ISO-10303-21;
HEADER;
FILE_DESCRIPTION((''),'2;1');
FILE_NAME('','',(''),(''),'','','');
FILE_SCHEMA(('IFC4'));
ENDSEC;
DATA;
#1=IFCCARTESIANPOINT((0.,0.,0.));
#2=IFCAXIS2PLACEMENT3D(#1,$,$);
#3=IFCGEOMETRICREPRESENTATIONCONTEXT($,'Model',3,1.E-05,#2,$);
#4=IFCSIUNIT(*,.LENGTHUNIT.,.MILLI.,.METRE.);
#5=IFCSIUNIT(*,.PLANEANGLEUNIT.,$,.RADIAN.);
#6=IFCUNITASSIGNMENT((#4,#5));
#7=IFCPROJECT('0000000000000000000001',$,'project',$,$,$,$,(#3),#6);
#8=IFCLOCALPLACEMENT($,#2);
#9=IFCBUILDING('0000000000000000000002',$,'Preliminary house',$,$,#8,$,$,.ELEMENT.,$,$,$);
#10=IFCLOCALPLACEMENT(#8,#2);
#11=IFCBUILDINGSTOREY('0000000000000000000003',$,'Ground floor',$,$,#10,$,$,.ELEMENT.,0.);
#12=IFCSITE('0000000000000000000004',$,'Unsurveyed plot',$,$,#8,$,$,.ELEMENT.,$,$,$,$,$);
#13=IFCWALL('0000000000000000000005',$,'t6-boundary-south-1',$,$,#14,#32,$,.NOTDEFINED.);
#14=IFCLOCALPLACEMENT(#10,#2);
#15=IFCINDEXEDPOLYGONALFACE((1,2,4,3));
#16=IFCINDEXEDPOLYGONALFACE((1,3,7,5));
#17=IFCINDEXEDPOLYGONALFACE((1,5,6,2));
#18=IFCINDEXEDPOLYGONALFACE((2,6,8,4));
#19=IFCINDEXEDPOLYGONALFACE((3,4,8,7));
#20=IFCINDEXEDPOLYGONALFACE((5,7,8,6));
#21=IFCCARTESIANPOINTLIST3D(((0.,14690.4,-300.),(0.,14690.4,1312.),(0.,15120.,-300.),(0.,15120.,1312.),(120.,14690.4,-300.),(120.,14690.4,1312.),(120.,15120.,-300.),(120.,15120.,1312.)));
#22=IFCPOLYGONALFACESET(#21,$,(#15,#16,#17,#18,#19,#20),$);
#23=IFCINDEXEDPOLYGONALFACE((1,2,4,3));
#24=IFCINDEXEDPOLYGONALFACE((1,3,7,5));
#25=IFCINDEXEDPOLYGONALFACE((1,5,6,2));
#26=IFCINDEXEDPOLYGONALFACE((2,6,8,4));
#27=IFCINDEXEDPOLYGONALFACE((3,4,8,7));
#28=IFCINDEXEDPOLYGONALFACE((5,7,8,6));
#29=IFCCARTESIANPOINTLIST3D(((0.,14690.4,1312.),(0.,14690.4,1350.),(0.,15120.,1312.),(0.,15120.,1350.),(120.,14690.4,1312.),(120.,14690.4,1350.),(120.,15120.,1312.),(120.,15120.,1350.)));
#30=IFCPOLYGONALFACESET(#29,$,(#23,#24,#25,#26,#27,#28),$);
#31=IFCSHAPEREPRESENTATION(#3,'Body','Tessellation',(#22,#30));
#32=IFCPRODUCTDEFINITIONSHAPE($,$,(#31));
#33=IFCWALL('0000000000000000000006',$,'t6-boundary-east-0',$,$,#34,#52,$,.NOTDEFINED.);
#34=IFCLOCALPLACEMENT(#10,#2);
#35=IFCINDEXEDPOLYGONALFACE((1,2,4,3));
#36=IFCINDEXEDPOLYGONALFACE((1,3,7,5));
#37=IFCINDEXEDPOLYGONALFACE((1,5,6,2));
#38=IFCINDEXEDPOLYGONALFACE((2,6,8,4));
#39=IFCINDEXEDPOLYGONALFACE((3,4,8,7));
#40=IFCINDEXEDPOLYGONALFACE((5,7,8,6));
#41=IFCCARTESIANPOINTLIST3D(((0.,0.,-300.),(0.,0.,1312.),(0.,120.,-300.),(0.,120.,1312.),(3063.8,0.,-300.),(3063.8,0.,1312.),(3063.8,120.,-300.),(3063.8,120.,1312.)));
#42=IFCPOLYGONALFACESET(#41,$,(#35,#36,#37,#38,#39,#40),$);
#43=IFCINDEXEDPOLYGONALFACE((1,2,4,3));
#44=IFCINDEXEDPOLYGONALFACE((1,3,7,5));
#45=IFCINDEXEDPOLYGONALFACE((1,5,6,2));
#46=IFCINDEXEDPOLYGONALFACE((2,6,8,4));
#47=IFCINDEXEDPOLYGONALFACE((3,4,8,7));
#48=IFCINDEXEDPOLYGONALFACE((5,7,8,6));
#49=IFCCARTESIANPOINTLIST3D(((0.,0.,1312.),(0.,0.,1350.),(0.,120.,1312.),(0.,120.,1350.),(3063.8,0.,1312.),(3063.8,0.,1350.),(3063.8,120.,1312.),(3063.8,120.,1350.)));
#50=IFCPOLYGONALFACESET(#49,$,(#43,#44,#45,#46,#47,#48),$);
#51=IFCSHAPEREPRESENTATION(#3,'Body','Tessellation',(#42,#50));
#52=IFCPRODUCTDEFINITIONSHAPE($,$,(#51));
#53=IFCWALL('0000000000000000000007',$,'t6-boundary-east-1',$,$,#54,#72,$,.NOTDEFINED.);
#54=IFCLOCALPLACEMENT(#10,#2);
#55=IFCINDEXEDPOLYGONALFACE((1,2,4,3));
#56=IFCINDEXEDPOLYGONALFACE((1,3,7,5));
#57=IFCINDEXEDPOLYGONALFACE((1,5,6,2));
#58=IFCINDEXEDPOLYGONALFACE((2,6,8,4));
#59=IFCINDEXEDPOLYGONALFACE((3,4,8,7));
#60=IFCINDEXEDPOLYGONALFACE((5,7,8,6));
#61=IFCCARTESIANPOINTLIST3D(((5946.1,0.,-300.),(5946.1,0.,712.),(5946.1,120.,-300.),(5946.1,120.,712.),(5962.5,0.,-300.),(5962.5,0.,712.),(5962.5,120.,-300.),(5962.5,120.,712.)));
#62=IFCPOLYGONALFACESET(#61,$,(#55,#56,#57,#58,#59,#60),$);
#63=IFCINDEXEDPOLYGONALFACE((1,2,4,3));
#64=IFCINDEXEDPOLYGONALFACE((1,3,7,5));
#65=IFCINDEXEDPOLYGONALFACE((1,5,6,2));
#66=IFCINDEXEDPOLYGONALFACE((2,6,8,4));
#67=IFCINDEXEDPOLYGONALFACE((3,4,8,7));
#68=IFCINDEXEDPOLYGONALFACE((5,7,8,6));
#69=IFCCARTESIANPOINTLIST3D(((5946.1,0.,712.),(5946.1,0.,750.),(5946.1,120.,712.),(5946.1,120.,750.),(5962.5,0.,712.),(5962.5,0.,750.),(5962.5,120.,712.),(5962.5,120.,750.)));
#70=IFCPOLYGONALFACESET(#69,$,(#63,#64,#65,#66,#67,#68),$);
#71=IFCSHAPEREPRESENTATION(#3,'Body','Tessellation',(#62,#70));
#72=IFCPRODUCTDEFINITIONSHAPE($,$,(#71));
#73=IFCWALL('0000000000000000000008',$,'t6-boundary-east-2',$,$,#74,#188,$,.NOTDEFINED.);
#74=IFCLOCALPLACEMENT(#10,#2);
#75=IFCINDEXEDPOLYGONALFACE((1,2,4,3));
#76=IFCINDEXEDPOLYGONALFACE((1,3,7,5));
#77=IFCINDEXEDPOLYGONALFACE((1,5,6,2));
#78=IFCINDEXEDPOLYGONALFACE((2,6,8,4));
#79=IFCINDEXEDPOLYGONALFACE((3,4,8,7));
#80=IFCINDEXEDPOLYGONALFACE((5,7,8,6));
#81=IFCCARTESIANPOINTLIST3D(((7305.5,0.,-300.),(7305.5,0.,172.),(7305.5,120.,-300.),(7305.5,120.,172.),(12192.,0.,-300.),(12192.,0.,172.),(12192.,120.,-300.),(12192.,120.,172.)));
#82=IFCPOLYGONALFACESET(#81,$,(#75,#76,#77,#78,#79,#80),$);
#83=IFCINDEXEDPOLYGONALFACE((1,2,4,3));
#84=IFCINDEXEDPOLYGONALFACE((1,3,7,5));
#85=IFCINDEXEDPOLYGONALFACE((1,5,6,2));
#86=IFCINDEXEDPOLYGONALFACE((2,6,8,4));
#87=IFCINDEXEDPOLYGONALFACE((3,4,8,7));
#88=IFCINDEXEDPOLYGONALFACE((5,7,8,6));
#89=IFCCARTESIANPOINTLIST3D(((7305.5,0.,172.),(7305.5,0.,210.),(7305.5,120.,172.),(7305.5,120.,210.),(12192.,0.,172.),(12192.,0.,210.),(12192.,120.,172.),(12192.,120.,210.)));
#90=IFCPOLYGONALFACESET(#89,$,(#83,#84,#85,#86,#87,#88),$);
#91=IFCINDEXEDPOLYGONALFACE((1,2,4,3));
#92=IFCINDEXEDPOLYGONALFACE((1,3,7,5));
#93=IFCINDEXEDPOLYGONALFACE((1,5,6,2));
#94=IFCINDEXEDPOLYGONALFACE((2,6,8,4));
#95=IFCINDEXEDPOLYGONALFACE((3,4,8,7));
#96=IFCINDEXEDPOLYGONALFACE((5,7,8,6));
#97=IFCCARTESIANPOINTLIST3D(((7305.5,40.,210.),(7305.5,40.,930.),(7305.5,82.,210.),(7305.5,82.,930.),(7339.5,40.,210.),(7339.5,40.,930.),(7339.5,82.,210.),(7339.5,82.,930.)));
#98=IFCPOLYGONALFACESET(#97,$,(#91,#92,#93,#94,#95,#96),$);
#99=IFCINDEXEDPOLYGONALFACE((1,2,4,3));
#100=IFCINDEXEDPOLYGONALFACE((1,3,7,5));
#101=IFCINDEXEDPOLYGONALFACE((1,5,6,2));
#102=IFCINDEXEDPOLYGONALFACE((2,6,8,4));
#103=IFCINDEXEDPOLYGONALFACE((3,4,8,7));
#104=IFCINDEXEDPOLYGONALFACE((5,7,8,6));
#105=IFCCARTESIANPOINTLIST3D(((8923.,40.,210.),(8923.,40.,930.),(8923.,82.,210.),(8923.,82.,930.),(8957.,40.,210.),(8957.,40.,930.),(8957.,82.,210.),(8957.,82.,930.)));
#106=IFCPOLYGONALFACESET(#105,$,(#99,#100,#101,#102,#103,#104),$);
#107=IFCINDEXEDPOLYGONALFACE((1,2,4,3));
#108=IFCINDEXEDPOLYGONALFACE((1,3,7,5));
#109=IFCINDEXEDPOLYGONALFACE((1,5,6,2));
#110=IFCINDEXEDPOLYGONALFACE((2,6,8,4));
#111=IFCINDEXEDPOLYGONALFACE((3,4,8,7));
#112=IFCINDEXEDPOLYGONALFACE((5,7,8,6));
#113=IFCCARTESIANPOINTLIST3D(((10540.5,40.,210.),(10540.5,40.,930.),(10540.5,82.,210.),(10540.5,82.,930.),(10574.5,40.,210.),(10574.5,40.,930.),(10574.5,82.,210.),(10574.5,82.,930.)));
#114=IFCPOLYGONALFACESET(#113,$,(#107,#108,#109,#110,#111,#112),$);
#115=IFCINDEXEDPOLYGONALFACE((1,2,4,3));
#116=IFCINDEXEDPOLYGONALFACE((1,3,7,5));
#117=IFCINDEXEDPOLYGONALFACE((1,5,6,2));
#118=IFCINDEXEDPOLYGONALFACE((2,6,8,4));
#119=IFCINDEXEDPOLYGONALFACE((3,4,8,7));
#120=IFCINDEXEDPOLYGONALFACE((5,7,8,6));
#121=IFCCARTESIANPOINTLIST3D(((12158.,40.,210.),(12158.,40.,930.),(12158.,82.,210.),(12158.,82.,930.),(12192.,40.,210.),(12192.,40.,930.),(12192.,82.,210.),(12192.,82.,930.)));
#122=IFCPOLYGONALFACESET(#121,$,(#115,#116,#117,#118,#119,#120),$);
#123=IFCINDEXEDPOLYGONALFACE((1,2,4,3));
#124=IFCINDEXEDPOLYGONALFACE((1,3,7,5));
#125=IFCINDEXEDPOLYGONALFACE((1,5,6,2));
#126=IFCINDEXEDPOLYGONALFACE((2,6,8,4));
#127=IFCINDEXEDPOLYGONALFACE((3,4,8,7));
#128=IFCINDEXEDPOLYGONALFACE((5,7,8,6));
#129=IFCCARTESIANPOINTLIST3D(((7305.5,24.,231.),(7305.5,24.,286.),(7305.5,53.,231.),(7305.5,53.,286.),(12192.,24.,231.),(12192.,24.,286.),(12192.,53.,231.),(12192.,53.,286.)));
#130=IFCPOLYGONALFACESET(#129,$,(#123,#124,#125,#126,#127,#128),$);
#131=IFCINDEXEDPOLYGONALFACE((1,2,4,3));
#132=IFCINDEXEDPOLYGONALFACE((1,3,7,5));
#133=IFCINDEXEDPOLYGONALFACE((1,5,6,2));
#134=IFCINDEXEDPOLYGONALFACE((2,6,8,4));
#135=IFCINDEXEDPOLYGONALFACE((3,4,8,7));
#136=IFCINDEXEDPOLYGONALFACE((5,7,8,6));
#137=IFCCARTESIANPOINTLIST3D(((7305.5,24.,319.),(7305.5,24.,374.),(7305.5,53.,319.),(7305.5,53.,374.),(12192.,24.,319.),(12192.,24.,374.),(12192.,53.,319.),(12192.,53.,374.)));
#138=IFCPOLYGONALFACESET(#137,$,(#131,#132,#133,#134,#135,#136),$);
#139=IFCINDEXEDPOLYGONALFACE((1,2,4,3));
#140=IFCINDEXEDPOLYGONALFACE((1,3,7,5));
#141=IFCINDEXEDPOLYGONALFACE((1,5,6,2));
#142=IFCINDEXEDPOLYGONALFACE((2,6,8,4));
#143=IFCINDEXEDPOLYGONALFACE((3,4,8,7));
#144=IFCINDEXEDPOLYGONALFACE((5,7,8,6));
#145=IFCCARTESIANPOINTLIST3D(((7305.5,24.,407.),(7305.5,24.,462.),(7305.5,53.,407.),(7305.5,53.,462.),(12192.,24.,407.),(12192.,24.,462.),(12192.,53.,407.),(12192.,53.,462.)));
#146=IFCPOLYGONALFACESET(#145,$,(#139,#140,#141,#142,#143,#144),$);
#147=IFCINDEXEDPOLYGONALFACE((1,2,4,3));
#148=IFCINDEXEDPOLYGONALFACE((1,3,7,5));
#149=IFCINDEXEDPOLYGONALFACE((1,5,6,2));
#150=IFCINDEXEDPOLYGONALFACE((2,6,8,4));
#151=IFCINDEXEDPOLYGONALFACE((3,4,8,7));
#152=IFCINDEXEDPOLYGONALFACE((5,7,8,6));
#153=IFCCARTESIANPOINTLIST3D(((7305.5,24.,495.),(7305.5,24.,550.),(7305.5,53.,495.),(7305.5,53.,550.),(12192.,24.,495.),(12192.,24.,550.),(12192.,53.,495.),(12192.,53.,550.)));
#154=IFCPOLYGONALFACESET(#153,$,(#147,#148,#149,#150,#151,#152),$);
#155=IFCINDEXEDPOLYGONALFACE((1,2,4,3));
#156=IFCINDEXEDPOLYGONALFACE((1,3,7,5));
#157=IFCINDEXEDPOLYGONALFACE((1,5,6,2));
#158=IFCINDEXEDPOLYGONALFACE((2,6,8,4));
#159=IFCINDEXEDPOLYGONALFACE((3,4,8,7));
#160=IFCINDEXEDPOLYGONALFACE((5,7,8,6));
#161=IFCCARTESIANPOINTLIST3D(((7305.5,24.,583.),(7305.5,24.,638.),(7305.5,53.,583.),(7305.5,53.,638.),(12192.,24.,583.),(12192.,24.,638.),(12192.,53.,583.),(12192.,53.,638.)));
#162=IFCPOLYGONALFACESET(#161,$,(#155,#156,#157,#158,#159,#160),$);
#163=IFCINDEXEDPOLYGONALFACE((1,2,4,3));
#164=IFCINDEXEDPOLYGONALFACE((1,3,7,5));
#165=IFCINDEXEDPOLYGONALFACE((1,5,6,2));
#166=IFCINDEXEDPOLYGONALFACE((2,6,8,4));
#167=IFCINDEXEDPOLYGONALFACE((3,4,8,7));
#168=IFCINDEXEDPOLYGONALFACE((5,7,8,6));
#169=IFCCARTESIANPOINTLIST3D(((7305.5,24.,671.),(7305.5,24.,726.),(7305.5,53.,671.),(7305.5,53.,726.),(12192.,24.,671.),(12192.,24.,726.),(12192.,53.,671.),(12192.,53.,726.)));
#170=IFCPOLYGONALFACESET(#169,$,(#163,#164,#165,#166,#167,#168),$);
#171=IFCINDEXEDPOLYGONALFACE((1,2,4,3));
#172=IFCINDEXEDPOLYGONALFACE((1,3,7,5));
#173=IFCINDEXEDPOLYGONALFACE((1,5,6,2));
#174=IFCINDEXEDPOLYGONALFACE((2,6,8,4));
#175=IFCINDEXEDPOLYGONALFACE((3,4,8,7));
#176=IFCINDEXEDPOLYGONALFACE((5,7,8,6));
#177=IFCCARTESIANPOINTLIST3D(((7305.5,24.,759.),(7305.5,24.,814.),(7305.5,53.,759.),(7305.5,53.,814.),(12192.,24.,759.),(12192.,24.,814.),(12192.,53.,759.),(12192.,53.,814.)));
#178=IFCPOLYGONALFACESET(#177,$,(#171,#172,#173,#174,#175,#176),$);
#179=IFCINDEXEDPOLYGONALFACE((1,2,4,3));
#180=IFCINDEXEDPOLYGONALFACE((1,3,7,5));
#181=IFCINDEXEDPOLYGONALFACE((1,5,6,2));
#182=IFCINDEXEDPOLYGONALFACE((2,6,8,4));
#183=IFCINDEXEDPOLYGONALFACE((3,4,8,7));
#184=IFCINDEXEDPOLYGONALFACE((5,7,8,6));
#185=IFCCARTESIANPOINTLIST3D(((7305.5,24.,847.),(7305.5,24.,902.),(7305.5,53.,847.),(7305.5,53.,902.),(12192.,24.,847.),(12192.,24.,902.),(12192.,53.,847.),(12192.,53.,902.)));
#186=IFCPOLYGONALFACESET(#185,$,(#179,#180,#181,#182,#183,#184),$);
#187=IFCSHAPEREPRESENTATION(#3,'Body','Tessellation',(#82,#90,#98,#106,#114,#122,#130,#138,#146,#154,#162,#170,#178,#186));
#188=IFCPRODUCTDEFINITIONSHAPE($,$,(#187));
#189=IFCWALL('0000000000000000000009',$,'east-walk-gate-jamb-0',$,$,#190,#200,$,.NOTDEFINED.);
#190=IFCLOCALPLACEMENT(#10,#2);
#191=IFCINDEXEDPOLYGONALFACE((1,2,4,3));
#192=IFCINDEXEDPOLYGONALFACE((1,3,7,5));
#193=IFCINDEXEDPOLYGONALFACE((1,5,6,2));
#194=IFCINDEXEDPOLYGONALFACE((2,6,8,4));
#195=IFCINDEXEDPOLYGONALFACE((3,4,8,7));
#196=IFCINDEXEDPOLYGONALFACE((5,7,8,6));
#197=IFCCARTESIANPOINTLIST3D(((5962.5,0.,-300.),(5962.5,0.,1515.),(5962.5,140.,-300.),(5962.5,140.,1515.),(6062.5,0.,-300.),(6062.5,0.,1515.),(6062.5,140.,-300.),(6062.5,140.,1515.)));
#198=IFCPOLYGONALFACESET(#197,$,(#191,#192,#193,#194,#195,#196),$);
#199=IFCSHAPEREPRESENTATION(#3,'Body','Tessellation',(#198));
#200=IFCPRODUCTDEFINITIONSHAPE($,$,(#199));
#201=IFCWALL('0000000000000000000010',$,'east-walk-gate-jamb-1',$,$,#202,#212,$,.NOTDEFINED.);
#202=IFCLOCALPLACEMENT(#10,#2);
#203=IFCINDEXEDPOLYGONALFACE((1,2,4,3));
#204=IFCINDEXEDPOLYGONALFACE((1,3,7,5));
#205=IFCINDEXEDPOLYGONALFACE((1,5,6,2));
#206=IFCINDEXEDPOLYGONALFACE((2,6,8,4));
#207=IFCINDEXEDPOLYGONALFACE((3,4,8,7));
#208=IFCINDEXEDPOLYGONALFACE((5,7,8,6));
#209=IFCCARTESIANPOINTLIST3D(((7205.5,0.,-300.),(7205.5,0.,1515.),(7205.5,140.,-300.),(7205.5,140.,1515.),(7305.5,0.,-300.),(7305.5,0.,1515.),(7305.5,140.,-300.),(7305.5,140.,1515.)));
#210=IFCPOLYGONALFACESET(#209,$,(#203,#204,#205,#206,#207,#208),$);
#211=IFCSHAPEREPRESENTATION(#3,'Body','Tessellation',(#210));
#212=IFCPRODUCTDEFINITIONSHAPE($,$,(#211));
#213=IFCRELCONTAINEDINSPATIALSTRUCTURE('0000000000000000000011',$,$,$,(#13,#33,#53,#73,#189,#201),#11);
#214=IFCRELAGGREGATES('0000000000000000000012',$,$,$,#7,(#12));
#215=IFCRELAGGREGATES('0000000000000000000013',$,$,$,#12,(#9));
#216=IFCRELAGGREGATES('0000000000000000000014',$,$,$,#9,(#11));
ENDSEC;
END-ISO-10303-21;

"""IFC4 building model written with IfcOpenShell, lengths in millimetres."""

from ifc_helpers import new_model, si_unit, frame, origin, place, context, project, spatial, polyline, outline, extrude, element, save


model = new_model("IFC4")

# Units and contexts
model_context = context("Model", 3, precision=1e-05, world=origin())
ifc_project = project(units=[si_unit("LENGTHUNIT", "METRE", prefix="MILLI"), si_unit("PLANEANGLEUNIT", "RADIAN")], contexts=[model_context])

# Site, building, storey
placement_1 = place(None, origin())
site = spatial("IfcSite", under=ifc_project, at=placement_1, Name="Unsurveyed plot", CompositionType="ELEMENT")
building = spatial("IfcBuilding", under=site, at=placement_1, Name="Preliminary house", CompositionType="ELEMENT")
placement_2 = place(placement_1, origin())
storey = spatial("IfcBuildingStorey", under=building, at=placement_2, Name="Ground floor", CompositionType="ELEMENT", Elevation=0.0)

# Walls
element("IfcWall", 1, at=placement_2, inside=storey, Name="t6-boundary-south-1", PredefinedType="NOTDEFINED", context=model_context, shape_type="SweptSolid", body=[
    extrude(outline(polyline([(120.0, 14690.4), (120.0, 15120.0), (0.0, 15120.0), (0.0, 14690.4), (120.0, 14690.4)])), frame((0.0, 0.0, -300.0)), (0.0, 0.0, 1.0), 1612.0),
    extrude(outline(polyline([(120.0, 14690.4), (120.0, 15120.0), (0.0, 15120.0), (0.0, 14690.4), (120.0, 14690.4)])), frame((0.0, 0.0, 1312.0)), (0.0, 0.0, 1.0), 38.0),
])
element("IfcWall", 2, at=placement_2, inside=storey, Name="t6-boundary-east-0", PredefinedType="NOTDEFINED", context=model_context, shape_type="SweptSolid", body=[
    extrude(outline(polyline([(3063.8, 0.0), (3063.8, 120.0), (0.0, 120.0), (0.0, 0.0), (3063.8, 0.0)])), frame((0.0, 0.0, -300.0)), (0.0, 0.0, 1.0), 1612.0),
    extrude(outline(polyline([(3063.8, 0.0), (3063.8, 120.0), (0.0, 120.0), (0.0, 0.0), (3063.8, 0.0)])), frame((0.0, 0.0, 1312.0)), (0.0, 0.0, 1.0), 38.0),
])
element("IfcWall", 3, at=placement_2, inside=storey, Name="t6-boundary-east-1", PredefinedType="NOTDEFINED", context=model_context, shape_type="SweptSolid", body=[
    extrude(outline(polyline([(5962.5, 0.0), (5962.5, 120.0), (5946.1, 120.0), (5946.1, 0.0), (5962.5, 0.0)])), frame((0.0, 0.0, -300.0)), (0.0, 0.0, 1.0), 1012.0),
    extrude(outline(polyline([(5962.5, 0.0), (5962.5, 120.0), (5946.1, 120.0), (5946.1, 0.0), (5962.5, 0.0)])), frame((0.0, 0.0, 712.0)), (0.0, 0.0, 1.0), 38.0),
])
element("IfcWall", 4, at=placement_2, inside=storey, Name="t6-boundary-east-2", PredefinedType="NOTDEFINED", context=model_context, shape_type="SweptSolid", body=[
    extrude(outline(polyline([(12192.0, 0.0), (12192.0, 120.0), (7305.5, 120.0), (7305.5, 0.0), (12192.0, 0.0)])), frame((0.0, 0.0, -300.0)), (0.0, 0.0, 1.0), 472.0),
    extrude(outline(polyline([(12192.0, 0.0), (12192.0, 120.0), (7305.5, 120.0), (7305.5, 0.0), (12192.0, 0.0)])), frame((0.0, 0.0, 172.0)), (0.0, 0.0, 1.0), 38.0),
    extrude(outline(polyline([(7339.5, 40.0), (7339.5, 82.0), (7305.5, 82.0), (7305.5, 40.0), (7339.5, 40.0)])), frame((0.0, 0.0, 210.0)), (0.0, 0.0, 1.0), 720.0),
    extrude(outline(polyline([(8957.0, 40.0), (8957.0, 82.0), (8923.0, 82.0), (8923.0, 40.0), (8957.0, 40.0)])), frame((0.0, 0.0, 210.0)), (0.0, 0.0, 1.0), 720.0),
    extrude(outline(polyline([(10574.5, 40.0), (10574.5, 82.0), (10540.5, 82.0), (10540.5, 40.0), (10574.5, 40.0)])), frame((0.0, 0.0, 210.0)), (0.0, 0.0, 1.0), 720.0),
    extrude(outline(polyline([(12192.0, 40.0), (12192.0, 82.0), (12158.0, 82.0), (12158.0, 40.0), (12192.0, 40.0)])), frame((0.0, 0.0, 210.0)), (0.0, 0.0, 1.0), 720.0),
    extrude(outline(polyline([(12192.0, 24.0), (12192.0, 53.0), (7305.5, 53.0), (7305.5, 24.0), (12192.0, 24.0)])), frame((0.0, 0.0, 231.0)), (0.0, 0.0, 1.0), 55.0),
    extrude(outline(polyline([(12192.0, 24.0), (12192.0, 53.0), (7305.5, 53.0), (7305.5, 24.0), (12192.0, 24.0)])), frame((0.0, 0.0, 319.0)), (0.0, 0.0, 1.0), 55.0),
    extrude(outline(polyline([(12192.0, 24.0), (12192.0, 53.0), (7305.5, 53.0), (7305.5, 24.0), (12192.0, 24.0)])), frame((0.0, 0.0, 407.0)), (0.0, 0.0, 1.0), 55.0),
    extrude(outline(polyline([(12192.0, 24.0), (12192.0, 53.0), (7305.5, 53.0), (7305.5, 24.0), (12192.0, 24.0)])), frame((0.0, 0.0, 495.0)), (0.0, 0.0, 1.0), 55.0),
    extrude(outline(polyline([(12192.0, 24.0), (12192.0, 53.0), (7305.5, 53.0), (7305.5, 24.0), (12192.0, 24.0)])), frame((0.0, 0.0, 583.0)), (0.0, 0.0, 1.0), 55.0),
    extrude(outline(polyline([(12192.0, 24.0), (12192.0, 53.0), (7305.5, 53.0), (7305.5, 24.0), (12192.0, 24.0)])), frame((0.0, 0.0, 671.0)), (0.0, 0.0, 1.0), 55.0),
    extrude(outline(polyline([(12192.0, 24.0), (12192.0, 53.0), (7305.5, 53.0), (7305.5, 24.0), (12192.0, 24.0)])), frame((0.0, 0.0, 759.0)), (0.0, 0.0, 1.0), 55.0),
    extrude(outline(polyline([(12192.0, 24.0), (12192.0, 53.0), (7305.5, 53.0), (7305.5, 24.0), (12192.0, 24.0)])), frame((0.0, 0.0, 847.0)), (0.0, 0.0, 1.0), 55.0),
])
element("IfcWall", 5, at=placement_2, inside=storey, Name="east-walk-gate-jamb-0", PredefinedType="NOTDEFINED", context=model_context, shape_type="SweptSolid", body=[
    extrude(outline(polyline([(6062.5, 0.0), (6062.5, 140.0), (5962.5, 140.0), (5962.5, 0.0), (6062.5, 0.0)])), frame((0.0, 0.0, -300.0)), (0.0, 0.0, 1.0), 1815.0),
])
element("IfcWall", 6, at=placement_2, inside=storey, Name="east-walk-gate-jamb-1", PredefinedType="NOTDEFINED", context=model_context, shape_type="SweptSolid", body=[
    extrude(outline(polyline([(7305.5, 0.0), (7305.5, 140.0), (7205.5, 140.0), (7205.5, 0.0), (7305.5, 0.0)])), frame((0.0, 0.0, -300.0)), (0.0, 0.0, 1.0), 1815.0),
])

save(model, "model.ifc")
